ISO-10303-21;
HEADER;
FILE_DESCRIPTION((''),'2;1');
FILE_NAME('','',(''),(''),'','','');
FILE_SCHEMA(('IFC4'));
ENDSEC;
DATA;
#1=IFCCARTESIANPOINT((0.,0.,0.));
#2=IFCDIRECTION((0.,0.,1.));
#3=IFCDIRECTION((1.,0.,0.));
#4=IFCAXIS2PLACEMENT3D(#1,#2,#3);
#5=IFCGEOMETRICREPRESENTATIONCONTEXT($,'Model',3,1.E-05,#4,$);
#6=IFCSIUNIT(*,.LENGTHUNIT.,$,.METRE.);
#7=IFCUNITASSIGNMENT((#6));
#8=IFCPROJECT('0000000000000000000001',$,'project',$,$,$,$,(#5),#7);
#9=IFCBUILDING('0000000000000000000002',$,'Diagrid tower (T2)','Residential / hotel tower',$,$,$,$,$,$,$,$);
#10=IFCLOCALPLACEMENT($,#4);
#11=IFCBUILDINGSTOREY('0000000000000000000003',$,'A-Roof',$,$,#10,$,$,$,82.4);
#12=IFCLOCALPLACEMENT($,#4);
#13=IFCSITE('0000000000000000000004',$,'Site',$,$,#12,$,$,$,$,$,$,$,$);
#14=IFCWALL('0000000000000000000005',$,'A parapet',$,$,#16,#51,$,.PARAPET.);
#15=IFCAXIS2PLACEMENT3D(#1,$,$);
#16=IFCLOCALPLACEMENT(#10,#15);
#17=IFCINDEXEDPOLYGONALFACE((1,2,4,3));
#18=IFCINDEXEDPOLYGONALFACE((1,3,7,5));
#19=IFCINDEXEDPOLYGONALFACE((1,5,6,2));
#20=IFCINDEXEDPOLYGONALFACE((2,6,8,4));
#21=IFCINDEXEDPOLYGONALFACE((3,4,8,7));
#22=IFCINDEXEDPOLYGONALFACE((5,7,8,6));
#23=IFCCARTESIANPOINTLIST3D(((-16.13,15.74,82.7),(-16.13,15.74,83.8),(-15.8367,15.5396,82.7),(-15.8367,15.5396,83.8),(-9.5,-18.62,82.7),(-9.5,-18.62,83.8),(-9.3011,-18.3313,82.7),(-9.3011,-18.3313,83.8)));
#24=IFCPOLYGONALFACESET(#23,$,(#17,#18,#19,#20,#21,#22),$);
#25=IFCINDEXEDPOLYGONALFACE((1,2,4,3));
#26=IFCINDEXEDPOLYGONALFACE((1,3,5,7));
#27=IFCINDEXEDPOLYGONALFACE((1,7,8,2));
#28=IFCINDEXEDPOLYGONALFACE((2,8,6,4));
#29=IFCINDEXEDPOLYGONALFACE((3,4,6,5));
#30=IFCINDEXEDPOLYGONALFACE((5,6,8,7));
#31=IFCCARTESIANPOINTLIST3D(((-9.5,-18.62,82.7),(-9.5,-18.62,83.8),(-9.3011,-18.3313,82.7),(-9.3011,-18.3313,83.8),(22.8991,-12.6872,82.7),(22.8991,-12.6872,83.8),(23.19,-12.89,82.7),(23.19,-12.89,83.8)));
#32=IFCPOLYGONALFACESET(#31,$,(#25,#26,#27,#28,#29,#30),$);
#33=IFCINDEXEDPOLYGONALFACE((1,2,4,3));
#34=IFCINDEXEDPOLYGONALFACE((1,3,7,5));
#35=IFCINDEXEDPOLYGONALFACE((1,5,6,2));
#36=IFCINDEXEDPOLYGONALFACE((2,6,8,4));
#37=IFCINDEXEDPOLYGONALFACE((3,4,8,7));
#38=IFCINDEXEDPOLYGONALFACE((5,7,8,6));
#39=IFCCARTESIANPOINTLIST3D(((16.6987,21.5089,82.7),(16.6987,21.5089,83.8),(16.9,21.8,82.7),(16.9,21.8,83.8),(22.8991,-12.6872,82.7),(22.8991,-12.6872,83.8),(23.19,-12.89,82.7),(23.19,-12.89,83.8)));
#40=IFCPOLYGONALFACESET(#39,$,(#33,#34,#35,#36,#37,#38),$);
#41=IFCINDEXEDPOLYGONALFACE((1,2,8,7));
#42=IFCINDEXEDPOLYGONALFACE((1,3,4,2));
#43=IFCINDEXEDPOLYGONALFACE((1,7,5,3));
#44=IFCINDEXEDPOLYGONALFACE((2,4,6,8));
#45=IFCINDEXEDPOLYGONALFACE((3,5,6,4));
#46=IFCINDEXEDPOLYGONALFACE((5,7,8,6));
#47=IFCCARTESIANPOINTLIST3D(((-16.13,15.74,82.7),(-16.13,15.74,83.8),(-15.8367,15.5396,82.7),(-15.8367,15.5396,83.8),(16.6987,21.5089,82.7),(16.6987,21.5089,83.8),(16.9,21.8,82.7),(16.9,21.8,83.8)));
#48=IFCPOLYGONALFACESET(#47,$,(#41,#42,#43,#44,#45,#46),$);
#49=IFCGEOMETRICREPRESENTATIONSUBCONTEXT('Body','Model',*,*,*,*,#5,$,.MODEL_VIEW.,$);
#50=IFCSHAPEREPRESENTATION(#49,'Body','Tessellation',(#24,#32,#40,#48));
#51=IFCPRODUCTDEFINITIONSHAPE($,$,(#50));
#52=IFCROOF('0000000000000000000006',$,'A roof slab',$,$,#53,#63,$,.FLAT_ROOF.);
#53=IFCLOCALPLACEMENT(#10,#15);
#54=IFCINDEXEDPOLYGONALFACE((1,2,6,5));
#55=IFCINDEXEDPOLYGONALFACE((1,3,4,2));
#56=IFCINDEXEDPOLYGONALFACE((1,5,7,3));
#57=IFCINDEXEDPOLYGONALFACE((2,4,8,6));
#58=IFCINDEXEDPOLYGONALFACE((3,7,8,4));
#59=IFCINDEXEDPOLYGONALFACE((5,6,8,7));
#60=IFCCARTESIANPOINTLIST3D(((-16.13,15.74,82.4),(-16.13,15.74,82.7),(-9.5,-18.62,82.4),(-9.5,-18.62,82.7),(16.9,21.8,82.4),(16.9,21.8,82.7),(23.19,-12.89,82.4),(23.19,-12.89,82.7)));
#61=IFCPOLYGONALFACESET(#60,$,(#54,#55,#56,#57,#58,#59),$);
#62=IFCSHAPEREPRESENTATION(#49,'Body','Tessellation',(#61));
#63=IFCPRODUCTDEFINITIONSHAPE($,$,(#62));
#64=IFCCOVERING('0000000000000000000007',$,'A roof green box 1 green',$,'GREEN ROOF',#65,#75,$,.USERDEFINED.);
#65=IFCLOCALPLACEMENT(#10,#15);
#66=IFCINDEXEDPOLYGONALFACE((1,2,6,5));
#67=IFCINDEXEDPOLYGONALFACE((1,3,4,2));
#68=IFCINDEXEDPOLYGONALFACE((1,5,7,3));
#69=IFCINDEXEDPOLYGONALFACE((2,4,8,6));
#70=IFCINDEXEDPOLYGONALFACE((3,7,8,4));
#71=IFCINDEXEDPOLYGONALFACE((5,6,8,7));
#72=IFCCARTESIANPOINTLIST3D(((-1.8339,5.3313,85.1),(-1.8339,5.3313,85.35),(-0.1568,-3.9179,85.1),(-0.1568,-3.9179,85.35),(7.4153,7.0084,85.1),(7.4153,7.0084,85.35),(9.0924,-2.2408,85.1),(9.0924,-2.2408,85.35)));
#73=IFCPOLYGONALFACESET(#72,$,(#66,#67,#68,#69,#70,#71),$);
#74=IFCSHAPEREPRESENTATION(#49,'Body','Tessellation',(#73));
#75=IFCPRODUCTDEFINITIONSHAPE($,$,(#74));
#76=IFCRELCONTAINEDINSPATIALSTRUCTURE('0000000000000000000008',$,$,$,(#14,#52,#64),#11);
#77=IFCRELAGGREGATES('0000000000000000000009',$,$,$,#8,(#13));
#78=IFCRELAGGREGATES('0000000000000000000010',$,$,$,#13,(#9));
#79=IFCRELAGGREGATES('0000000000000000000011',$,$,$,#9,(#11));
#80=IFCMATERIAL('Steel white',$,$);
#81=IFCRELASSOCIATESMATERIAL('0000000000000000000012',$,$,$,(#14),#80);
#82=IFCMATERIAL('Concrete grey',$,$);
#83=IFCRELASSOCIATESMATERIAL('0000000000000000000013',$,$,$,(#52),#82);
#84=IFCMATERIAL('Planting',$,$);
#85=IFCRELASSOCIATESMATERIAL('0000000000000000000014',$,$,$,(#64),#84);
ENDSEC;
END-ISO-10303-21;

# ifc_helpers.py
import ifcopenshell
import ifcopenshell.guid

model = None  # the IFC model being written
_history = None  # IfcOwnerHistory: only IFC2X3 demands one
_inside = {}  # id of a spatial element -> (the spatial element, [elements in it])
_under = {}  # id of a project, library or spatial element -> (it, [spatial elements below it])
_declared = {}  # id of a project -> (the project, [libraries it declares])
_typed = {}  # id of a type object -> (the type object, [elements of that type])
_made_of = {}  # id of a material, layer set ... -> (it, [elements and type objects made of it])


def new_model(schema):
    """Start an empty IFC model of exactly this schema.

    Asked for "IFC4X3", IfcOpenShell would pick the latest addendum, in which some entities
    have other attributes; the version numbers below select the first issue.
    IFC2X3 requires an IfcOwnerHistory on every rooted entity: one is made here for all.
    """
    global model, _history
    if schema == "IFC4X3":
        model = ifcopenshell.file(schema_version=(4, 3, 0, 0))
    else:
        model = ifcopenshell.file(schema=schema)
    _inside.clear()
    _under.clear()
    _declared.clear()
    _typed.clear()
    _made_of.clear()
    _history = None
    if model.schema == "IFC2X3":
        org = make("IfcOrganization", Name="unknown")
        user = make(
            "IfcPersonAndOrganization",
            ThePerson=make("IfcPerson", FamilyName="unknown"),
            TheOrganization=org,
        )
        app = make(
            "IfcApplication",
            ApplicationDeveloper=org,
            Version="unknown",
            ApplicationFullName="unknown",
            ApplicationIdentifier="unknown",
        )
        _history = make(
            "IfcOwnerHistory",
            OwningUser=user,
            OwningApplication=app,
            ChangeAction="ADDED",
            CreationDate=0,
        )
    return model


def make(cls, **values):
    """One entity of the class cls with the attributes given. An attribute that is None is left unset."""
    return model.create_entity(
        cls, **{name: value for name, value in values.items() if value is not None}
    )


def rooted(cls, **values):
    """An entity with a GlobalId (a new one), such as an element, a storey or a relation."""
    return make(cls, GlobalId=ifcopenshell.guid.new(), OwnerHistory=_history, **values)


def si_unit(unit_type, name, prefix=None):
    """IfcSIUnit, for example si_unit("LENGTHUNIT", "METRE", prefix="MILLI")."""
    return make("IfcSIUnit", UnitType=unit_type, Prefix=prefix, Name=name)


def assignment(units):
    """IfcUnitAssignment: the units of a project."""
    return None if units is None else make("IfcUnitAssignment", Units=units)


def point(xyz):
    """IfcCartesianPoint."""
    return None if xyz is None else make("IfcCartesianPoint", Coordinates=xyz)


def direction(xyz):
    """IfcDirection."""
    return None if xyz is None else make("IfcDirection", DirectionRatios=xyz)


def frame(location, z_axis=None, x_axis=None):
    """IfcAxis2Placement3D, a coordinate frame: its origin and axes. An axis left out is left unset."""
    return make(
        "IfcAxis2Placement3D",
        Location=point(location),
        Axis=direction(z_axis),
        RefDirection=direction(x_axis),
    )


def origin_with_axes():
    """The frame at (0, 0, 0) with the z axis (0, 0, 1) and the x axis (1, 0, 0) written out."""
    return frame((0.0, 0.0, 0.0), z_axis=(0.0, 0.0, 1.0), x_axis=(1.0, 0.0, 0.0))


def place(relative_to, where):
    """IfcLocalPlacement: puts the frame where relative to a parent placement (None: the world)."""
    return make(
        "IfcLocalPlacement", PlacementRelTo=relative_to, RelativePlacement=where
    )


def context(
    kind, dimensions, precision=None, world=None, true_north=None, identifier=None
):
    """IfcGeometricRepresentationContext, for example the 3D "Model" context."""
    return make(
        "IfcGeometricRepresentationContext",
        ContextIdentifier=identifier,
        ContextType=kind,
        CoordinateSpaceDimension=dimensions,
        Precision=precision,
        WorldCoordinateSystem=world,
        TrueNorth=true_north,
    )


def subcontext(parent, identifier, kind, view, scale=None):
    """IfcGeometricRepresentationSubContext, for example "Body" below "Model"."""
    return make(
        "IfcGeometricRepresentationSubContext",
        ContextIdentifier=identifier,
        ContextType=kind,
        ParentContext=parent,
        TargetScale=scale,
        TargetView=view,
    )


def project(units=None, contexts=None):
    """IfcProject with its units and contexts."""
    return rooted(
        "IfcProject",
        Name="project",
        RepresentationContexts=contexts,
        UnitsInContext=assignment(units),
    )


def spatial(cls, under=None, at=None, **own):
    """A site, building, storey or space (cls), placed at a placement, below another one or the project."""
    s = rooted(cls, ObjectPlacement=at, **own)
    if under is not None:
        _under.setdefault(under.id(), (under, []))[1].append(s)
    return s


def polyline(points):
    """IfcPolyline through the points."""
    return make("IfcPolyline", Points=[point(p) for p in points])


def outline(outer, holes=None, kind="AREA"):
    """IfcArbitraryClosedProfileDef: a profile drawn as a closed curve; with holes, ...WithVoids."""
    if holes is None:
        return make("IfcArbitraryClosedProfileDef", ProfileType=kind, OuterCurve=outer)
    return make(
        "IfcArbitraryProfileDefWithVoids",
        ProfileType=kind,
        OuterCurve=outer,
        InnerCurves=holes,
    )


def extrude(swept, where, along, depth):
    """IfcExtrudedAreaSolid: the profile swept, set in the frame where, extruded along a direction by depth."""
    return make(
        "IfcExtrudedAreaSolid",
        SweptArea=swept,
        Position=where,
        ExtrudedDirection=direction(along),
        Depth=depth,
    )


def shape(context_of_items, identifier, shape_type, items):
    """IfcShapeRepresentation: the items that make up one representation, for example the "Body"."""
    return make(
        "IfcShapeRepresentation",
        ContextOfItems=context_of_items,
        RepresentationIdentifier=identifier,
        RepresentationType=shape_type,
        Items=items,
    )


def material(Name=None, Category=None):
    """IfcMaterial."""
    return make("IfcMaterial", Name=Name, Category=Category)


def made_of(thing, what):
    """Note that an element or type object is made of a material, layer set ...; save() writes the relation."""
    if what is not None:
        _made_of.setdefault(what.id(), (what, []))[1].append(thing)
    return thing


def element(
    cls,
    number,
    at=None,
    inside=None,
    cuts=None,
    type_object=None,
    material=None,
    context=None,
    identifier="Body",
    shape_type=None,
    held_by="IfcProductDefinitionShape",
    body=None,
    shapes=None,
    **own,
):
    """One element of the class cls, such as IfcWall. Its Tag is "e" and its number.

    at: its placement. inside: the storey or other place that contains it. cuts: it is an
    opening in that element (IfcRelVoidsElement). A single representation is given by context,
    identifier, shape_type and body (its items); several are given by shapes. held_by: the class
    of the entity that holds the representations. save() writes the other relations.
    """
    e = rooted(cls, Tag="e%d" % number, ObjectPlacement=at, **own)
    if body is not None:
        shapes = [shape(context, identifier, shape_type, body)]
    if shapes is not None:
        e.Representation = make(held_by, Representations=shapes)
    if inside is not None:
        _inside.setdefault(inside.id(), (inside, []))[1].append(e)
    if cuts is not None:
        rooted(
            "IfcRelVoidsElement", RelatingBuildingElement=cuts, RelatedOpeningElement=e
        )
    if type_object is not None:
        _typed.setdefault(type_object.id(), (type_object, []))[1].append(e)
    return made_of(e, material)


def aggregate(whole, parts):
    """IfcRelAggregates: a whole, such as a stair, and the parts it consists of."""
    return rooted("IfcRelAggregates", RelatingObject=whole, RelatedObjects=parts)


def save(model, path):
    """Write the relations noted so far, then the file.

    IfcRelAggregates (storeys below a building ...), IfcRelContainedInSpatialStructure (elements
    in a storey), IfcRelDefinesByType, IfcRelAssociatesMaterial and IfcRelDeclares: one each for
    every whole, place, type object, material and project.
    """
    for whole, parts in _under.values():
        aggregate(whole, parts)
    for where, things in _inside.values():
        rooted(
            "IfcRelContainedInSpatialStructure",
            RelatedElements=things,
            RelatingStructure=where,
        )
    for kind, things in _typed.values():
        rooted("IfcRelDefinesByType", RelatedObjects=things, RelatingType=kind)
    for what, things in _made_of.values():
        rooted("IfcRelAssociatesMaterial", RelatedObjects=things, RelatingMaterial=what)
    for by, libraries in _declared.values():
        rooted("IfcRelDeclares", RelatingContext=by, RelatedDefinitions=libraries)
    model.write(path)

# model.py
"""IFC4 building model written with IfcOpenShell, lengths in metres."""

from ifc_helpers import new_model, si_unit, frame, origin_with_axes, place, context, subcontext, project, spatial, polyline, outline, extrude, material, element, save


model = new_model("IFC4")

# Units and contexts
model_context = context("Model", 3, precision=1e-05, world=origin_with_axes())
body_context = subcontext(model_context, "Body", "Model", "MODEL_VIEW")
ifc_project = project(units=[si_unit("LENGTHUNIT", "METRE")], contexts=[model_context])

# Site, building, storey
site_placement = place(None, origin_with_axes())
site = spatial("IfcSite", under=ifc_project, at=site_placement, Name="Site")
building = spatial("IfcBuilding", under=site, Name="Diagrid tower (T2)", Description="Residential / hotel tower")
storey_placement = place(None, origin_with_axes())
storey = spatial("IfcBuildingStorey", under=building, at=storey_placement, Name="A-Roof", Elevation=82.4)

# Wall
ifc_material_1 = material(Name="Steel white")
wall_placement = place(storey_placement, origin_with_axes())
element("IfcWall", 1, at=wall_placement, inside=storey, material=ifc_material_1, Name="A parapet", PredefinedType="PARAPET", context=body_context, shape_type="SweptSolid", body=[
    extrude(outline(polyline([(-16.13, 15.74), (-9.5, -18.62), (-9.3011, -18.3313), (-15.8367, 15.5396), (-16.13, 15.74)])), frame((0.0, 0.0, 82.7), z_axis=(0.0, 0.0, 1.0), x_axis=(1.0, 0.0, 0.0)), (0.0, 0.0, 1.0), 1.1),
    extrude(outline(polyline([(-9.5, -18.62), (23.19, -12.89), (22.8991, -12.6872), (-9.3011, -18.3313), (-9.5, -18.62)])), frame((0.0, 0.0, 82.7), z_axis=(0.0, 0.0, 1.0), x_axis=(1.0, 0.0, 0.0)), (0.0, 0.0, 1.0), 1.1),
    extrude(outline(polyline([(23.19, -12.89), (16.9, 21.8), (16.6987, 21.5089), (22.8991, -12.6872), (23.19, -12.89)])), frame((0.0, 0.0, 82.7), z_axis=(0.0, 0.0, 1.0), x_axis=(1.0, 0.0, 0.0)), (0.0, 0.0, 1.0), 1.1),
    extrude(outline(polyline([(16.9, 21.8), (-16.13, 15.74), (-15.8367, 15.5396), (16.6987, 21.5089), (16.9, 21.8)])), frame((0.0, 0.0, 82.7), z_axis=(0.0, 0.0, 1.0), x_axis=(1.0, 0.0, 0.0)), (0.0, 0.0, 1.0), 1.1),
])

# Roof
ifc_material_2 = material(Name="Concrete grey")
roof_placement = place(storey_placement, origin_with_axes())
element("IfcRoof", 2, at=roof_placement, inside=storey, material=ifc_material_2, Name="A roof slab", PredefinedType="FLAT_ROOF", context=body_context, shape_type="SweptSolid", body=[
    extrude(outline(polyline([(-16.13, 15.74), (-9.5, -18.62), (23.19, -12.89), (16.9, 21.8), (-16.13, 15.74)])), frame((0.0, 0.0, 82.4), z_axis=(0.0, 0.0, 1.0), x_axis=(1.0, 0.0, 0.0)), (0.0, 0.0, 1.0), 0.3),
])

# Covering
ifc_material_3 = material(Name="Planting")
covering_placement = place(storey_placement, origin_with_axes())
element("IfcCovering", 3, at=covering_placement, inside=storey, material=ifc_material_3, Name="A roof green box 1 green", ObjectType="GREEN ROOF", PredefinedType="USERDEFINED", context=body_context, shape_type="SweptSolid", body=[
    extrude(outline(polyline([(9.0924, -2.2408), (7.4153, 7.0084), (-1.8339, 5.3313), (-0.1568, -3.9179), (9.0924, -2.2408)])), frame((0.0, 0.0, 85.1), z_axis=(0.0, 0.0, 1.0), x_axis=(1.0, 0.0, 0.0)), (0.0, 0.0, 1.0), 0.25),
])

save(model, "model.ifc")
